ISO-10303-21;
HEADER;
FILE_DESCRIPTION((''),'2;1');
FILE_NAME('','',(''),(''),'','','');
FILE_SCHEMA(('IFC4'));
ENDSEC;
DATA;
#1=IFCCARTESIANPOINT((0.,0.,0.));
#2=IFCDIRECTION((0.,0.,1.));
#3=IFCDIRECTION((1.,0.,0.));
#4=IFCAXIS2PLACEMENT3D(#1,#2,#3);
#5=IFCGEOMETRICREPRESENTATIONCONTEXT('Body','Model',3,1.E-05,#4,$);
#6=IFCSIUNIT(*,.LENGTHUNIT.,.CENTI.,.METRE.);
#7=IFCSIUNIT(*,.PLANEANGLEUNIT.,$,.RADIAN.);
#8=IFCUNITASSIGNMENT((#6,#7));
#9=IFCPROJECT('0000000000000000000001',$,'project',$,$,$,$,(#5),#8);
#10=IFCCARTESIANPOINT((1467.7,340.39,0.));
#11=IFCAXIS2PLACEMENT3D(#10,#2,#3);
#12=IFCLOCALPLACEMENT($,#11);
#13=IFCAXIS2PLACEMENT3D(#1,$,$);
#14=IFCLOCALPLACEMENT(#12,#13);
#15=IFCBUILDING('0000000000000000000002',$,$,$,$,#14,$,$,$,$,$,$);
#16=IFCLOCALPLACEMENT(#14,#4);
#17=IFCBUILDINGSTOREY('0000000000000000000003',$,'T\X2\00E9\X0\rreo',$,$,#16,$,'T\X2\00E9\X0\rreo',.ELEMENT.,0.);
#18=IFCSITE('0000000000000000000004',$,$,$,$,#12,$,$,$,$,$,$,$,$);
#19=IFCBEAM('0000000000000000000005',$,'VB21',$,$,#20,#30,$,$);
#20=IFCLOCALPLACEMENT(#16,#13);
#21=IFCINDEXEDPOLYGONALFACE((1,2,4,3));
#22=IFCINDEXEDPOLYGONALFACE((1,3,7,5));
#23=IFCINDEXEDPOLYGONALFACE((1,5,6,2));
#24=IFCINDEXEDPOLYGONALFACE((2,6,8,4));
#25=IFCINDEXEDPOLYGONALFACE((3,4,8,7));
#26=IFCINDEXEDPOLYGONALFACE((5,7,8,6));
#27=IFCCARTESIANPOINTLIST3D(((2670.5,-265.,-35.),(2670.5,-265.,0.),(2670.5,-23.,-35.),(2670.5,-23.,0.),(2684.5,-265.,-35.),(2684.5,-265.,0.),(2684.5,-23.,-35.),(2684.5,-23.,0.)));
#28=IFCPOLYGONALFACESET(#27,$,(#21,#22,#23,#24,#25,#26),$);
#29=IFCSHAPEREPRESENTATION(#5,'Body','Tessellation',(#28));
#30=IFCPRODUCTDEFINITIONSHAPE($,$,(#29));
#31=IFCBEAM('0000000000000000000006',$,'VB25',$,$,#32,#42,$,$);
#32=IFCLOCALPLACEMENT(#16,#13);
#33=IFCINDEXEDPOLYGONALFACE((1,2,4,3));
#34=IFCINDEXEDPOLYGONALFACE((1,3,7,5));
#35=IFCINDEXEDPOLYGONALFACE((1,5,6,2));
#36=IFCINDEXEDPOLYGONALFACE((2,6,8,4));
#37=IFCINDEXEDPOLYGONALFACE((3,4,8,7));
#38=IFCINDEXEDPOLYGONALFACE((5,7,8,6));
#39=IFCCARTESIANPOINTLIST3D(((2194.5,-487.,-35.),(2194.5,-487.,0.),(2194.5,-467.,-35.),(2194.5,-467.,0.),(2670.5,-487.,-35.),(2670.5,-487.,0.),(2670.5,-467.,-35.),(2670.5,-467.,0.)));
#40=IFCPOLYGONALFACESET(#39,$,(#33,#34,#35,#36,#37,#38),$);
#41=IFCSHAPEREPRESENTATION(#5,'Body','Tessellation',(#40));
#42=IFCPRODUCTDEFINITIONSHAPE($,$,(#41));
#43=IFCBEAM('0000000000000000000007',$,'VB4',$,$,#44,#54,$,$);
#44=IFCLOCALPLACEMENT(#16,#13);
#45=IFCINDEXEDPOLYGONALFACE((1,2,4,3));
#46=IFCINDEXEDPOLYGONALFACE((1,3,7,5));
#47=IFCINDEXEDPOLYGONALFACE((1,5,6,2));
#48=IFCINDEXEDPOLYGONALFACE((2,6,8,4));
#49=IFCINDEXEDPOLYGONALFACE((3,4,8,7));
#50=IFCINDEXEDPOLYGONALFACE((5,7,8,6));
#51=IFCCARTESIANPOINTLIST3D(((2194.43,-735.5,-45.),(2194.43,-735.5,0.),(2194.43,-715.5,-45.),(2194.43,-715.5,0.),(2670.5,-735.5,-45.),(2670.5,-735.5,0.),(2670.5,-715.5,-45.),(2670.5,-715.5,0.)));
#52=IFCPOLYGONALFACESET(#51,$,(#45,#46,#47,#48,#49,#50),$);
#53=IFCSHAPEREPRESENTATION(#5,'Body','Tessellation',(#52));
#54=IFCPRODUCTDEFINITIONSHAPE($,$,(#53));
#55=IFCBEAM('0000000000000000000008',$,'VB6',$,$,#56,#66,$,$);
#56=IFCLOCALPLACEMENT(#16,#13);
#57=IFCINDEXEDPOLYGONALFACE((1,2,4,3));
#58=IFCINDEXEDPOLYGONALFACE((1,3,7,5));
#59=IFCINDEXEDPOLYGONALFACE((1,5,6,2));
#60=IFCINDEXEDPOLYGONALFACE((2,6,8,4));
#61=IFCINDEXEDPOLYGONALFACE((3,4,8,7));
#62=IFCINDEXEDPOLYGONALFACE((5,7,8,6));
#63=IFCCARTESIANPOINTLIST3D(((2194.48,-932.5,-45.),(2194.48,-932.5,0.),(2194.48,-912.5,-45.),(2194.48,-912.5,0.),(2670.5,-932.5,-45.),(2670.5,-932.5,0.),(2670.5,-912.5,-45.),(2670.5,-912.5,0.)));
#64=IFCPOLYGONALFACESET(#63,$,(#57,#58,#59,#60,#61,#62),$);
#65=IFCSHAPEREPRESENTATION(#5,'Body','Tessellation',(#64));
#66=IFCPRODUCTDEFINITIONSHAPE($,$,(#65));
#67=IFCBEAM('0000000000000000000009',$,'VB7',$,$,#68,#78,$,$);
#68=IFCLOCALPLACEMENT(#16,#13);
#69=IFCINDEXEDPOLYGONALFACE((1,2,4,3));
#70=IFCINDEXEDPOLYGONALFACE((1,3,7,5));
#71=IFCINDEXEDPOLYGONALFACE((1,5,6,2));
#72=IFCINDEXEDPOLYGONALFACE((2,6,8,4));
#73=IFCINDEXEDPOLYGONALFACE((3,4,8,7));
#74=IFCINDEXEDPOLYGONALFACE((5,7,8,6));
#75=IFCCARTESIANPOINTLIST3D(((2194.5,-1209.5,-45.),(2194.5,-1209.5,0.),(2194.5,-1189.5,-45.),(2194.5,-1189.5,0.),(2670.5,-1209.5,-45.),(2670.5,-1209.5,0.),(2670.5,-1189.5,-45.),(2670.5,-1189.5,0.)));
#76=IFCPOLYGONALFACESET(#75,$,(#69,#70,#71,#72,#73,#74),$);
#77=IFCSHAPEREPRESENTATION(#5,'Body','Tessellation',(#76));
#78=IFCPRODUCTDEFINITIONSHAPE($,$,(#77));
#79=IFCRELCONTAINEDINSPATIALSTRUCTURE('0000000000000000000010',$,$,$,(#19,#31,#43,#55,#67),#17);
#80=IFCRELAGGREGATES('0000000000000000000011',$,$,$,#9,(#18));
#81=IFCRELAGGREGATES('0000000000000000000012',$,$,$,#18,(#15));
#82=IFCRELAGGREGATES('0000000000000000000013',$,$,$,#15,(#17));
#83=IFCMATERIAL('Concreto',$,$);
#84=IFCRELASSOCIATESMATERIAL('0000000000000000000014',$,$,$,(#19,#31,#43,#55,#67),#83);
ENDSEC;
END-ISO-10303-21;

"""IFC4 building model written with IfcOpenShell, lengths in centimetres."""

from ifc_helpers import new_model, si_unit, frame, origin, origin_with_axes, origin_2d_with_axis, place, context, project, spatial, rectangle, extrude, material, element, save


model = new_model("IFC4")

# Units and contexts
model_context = context("Model", 3, precision=1e-05, world=origin_with_axes(), identifier="Body")
ifc_project = project(units=[si_unit("LENGTHUNIT", "METRE", prefix="CENTI"), si_unit("PLANEANGLEUNIT", "RADIAN")], contexts=[model_context])

# Site, building, storey
site_placement = place(None, frame((1467.7, 340.39, 0.0), z_axis=(0.0, 0.0, 1.0), x_axis=(1.0, 0.0, 0.0)))
site = spatial("IfcSite", under=ifc_project, at=site_placement)
building_placement = place(site_placement, origin())
building = spatial("IfcBuilding", under=site, at=building_placement)
storey_placement = place(building_placement, origin_with_axes())
storey = spatial("IfcBuildingStorey", under=building, at=storey_placement, Name="Térreo", LongName="Térreo", CompositionType="ELEMENT", Elevation=0.0)

# Shared definitions
ifc_material = material(Name="Concreto")

# Beams
beam_1_placement = place(storey_placement, frame((2677.5, -144.0, 0.0), z_axis=(0.0, 0.0, 1.0), x_axis=(1.0, 0.0, 0.0)))
element("IfcBeam", 1, at=beam_1_placement, inside=storey, material=ifc_material, Name="VB21", context=model_context, shape_type="SolidModel", body=[
    extrude(rectangle(XDim=14.0, YDim=35.0, at=origin_2d_with_axis()), frame((0.0, -121.0, -17.5), z_axis=(0.0, 1.0, 0.0), x_axis=(1.0, 0.0, 0.0)), (0.0, 0.0, 1.0), 242.0),
])
beam_2_placement = place(storey_placement, frame((2432.5, -477.0, 0.0), z_axis=(0.0, 0.0, 1.0), x_axis=(1.0, 0.0, 0.0)))
element("IfcBeam", 2, at=beam_2_placement, inside=storey, material=ifc_material, Name="VB25", context=model_context, shape_type="SolidModel", body=[
    extrude(rectangle(XDim=20.0, YDim=35.0, at=origin_2d_with_axis()), frame((-238.0, 0.0, -17.5), z_axis=(1.0, 0.0, 0.0), x_axis=(0.0, 1.0, 0.0)), (0.0, 0.0, 1.0), 476.0),
])
beam_3_placement = place(storey_placement, frame((2432.47, -725.5, 0.0), z_axis=(0.0, 0.0, 1.0), x_axis=(1.0, 0.0, 0.0)))
element("IfcBeam", 3, at=beam_3_placement, inside=storey, material=ifc_material, Name="VB4", context=model_context, shape_type="SolidModel", body=[
    extrude(rectangle(XDim=20.0, YDim=45.0, at=origin_2d_with_axis()), frame((-238.03, 0.0, -22.5), z_axis=(1.0, 0.0, 0.0), x_axis=(0.0, 1.0, 0.0)), (0.0, 0.0, 1.0), 476.07),
])
beam_4_placement = place(storey_placement, frame((2432.49, -922.5, 0.0), z_axis=(0.0, 0.0, 1.0), x_axis=(1.0, 0.0, 0.0)))
element("IfcBeam", 4, at=beam_4_placement, inside=storey, material=ifc_material, Name="VB6", context=model_context, shape_type="SolidModel", body=[
    extrude(rectangle(XDim=20.0, YDim=45.0, at=origin_2d_with_axis()), frame((-238.01, 0.0, -22.5), z_axis=(1.0, 0.0, 0.0), x_axis=(0.0, 1.0, 0.0)), (0.0, 0.0, 1.0), 476.02),
])
beam_5_placement = place(storey_placement, frame((2432.5, -1199.5, 0.0), z_axis=(0.0, 0.0, 1.0), x_axis=(1.0, 0.0, 0.0)))
element("IfcBeam", 5, at=beam_5_placement, inside=storey, material=ifc_material, Name="VB7", context=model_context, shape_type="SolidModel", body=[
    extrude(rectangle(XDim=20.0, YDim=45.0, at=origin_2d_with_axis()), frame((-238.0, 0.0, -22.5), z_axis=(1.0, 0.0, 0.0), x_axis=(0.0, 1.0, 0.0)), (0.0, 0.0, 1.0), 476.0),
])

save(model, "model.ifc")
